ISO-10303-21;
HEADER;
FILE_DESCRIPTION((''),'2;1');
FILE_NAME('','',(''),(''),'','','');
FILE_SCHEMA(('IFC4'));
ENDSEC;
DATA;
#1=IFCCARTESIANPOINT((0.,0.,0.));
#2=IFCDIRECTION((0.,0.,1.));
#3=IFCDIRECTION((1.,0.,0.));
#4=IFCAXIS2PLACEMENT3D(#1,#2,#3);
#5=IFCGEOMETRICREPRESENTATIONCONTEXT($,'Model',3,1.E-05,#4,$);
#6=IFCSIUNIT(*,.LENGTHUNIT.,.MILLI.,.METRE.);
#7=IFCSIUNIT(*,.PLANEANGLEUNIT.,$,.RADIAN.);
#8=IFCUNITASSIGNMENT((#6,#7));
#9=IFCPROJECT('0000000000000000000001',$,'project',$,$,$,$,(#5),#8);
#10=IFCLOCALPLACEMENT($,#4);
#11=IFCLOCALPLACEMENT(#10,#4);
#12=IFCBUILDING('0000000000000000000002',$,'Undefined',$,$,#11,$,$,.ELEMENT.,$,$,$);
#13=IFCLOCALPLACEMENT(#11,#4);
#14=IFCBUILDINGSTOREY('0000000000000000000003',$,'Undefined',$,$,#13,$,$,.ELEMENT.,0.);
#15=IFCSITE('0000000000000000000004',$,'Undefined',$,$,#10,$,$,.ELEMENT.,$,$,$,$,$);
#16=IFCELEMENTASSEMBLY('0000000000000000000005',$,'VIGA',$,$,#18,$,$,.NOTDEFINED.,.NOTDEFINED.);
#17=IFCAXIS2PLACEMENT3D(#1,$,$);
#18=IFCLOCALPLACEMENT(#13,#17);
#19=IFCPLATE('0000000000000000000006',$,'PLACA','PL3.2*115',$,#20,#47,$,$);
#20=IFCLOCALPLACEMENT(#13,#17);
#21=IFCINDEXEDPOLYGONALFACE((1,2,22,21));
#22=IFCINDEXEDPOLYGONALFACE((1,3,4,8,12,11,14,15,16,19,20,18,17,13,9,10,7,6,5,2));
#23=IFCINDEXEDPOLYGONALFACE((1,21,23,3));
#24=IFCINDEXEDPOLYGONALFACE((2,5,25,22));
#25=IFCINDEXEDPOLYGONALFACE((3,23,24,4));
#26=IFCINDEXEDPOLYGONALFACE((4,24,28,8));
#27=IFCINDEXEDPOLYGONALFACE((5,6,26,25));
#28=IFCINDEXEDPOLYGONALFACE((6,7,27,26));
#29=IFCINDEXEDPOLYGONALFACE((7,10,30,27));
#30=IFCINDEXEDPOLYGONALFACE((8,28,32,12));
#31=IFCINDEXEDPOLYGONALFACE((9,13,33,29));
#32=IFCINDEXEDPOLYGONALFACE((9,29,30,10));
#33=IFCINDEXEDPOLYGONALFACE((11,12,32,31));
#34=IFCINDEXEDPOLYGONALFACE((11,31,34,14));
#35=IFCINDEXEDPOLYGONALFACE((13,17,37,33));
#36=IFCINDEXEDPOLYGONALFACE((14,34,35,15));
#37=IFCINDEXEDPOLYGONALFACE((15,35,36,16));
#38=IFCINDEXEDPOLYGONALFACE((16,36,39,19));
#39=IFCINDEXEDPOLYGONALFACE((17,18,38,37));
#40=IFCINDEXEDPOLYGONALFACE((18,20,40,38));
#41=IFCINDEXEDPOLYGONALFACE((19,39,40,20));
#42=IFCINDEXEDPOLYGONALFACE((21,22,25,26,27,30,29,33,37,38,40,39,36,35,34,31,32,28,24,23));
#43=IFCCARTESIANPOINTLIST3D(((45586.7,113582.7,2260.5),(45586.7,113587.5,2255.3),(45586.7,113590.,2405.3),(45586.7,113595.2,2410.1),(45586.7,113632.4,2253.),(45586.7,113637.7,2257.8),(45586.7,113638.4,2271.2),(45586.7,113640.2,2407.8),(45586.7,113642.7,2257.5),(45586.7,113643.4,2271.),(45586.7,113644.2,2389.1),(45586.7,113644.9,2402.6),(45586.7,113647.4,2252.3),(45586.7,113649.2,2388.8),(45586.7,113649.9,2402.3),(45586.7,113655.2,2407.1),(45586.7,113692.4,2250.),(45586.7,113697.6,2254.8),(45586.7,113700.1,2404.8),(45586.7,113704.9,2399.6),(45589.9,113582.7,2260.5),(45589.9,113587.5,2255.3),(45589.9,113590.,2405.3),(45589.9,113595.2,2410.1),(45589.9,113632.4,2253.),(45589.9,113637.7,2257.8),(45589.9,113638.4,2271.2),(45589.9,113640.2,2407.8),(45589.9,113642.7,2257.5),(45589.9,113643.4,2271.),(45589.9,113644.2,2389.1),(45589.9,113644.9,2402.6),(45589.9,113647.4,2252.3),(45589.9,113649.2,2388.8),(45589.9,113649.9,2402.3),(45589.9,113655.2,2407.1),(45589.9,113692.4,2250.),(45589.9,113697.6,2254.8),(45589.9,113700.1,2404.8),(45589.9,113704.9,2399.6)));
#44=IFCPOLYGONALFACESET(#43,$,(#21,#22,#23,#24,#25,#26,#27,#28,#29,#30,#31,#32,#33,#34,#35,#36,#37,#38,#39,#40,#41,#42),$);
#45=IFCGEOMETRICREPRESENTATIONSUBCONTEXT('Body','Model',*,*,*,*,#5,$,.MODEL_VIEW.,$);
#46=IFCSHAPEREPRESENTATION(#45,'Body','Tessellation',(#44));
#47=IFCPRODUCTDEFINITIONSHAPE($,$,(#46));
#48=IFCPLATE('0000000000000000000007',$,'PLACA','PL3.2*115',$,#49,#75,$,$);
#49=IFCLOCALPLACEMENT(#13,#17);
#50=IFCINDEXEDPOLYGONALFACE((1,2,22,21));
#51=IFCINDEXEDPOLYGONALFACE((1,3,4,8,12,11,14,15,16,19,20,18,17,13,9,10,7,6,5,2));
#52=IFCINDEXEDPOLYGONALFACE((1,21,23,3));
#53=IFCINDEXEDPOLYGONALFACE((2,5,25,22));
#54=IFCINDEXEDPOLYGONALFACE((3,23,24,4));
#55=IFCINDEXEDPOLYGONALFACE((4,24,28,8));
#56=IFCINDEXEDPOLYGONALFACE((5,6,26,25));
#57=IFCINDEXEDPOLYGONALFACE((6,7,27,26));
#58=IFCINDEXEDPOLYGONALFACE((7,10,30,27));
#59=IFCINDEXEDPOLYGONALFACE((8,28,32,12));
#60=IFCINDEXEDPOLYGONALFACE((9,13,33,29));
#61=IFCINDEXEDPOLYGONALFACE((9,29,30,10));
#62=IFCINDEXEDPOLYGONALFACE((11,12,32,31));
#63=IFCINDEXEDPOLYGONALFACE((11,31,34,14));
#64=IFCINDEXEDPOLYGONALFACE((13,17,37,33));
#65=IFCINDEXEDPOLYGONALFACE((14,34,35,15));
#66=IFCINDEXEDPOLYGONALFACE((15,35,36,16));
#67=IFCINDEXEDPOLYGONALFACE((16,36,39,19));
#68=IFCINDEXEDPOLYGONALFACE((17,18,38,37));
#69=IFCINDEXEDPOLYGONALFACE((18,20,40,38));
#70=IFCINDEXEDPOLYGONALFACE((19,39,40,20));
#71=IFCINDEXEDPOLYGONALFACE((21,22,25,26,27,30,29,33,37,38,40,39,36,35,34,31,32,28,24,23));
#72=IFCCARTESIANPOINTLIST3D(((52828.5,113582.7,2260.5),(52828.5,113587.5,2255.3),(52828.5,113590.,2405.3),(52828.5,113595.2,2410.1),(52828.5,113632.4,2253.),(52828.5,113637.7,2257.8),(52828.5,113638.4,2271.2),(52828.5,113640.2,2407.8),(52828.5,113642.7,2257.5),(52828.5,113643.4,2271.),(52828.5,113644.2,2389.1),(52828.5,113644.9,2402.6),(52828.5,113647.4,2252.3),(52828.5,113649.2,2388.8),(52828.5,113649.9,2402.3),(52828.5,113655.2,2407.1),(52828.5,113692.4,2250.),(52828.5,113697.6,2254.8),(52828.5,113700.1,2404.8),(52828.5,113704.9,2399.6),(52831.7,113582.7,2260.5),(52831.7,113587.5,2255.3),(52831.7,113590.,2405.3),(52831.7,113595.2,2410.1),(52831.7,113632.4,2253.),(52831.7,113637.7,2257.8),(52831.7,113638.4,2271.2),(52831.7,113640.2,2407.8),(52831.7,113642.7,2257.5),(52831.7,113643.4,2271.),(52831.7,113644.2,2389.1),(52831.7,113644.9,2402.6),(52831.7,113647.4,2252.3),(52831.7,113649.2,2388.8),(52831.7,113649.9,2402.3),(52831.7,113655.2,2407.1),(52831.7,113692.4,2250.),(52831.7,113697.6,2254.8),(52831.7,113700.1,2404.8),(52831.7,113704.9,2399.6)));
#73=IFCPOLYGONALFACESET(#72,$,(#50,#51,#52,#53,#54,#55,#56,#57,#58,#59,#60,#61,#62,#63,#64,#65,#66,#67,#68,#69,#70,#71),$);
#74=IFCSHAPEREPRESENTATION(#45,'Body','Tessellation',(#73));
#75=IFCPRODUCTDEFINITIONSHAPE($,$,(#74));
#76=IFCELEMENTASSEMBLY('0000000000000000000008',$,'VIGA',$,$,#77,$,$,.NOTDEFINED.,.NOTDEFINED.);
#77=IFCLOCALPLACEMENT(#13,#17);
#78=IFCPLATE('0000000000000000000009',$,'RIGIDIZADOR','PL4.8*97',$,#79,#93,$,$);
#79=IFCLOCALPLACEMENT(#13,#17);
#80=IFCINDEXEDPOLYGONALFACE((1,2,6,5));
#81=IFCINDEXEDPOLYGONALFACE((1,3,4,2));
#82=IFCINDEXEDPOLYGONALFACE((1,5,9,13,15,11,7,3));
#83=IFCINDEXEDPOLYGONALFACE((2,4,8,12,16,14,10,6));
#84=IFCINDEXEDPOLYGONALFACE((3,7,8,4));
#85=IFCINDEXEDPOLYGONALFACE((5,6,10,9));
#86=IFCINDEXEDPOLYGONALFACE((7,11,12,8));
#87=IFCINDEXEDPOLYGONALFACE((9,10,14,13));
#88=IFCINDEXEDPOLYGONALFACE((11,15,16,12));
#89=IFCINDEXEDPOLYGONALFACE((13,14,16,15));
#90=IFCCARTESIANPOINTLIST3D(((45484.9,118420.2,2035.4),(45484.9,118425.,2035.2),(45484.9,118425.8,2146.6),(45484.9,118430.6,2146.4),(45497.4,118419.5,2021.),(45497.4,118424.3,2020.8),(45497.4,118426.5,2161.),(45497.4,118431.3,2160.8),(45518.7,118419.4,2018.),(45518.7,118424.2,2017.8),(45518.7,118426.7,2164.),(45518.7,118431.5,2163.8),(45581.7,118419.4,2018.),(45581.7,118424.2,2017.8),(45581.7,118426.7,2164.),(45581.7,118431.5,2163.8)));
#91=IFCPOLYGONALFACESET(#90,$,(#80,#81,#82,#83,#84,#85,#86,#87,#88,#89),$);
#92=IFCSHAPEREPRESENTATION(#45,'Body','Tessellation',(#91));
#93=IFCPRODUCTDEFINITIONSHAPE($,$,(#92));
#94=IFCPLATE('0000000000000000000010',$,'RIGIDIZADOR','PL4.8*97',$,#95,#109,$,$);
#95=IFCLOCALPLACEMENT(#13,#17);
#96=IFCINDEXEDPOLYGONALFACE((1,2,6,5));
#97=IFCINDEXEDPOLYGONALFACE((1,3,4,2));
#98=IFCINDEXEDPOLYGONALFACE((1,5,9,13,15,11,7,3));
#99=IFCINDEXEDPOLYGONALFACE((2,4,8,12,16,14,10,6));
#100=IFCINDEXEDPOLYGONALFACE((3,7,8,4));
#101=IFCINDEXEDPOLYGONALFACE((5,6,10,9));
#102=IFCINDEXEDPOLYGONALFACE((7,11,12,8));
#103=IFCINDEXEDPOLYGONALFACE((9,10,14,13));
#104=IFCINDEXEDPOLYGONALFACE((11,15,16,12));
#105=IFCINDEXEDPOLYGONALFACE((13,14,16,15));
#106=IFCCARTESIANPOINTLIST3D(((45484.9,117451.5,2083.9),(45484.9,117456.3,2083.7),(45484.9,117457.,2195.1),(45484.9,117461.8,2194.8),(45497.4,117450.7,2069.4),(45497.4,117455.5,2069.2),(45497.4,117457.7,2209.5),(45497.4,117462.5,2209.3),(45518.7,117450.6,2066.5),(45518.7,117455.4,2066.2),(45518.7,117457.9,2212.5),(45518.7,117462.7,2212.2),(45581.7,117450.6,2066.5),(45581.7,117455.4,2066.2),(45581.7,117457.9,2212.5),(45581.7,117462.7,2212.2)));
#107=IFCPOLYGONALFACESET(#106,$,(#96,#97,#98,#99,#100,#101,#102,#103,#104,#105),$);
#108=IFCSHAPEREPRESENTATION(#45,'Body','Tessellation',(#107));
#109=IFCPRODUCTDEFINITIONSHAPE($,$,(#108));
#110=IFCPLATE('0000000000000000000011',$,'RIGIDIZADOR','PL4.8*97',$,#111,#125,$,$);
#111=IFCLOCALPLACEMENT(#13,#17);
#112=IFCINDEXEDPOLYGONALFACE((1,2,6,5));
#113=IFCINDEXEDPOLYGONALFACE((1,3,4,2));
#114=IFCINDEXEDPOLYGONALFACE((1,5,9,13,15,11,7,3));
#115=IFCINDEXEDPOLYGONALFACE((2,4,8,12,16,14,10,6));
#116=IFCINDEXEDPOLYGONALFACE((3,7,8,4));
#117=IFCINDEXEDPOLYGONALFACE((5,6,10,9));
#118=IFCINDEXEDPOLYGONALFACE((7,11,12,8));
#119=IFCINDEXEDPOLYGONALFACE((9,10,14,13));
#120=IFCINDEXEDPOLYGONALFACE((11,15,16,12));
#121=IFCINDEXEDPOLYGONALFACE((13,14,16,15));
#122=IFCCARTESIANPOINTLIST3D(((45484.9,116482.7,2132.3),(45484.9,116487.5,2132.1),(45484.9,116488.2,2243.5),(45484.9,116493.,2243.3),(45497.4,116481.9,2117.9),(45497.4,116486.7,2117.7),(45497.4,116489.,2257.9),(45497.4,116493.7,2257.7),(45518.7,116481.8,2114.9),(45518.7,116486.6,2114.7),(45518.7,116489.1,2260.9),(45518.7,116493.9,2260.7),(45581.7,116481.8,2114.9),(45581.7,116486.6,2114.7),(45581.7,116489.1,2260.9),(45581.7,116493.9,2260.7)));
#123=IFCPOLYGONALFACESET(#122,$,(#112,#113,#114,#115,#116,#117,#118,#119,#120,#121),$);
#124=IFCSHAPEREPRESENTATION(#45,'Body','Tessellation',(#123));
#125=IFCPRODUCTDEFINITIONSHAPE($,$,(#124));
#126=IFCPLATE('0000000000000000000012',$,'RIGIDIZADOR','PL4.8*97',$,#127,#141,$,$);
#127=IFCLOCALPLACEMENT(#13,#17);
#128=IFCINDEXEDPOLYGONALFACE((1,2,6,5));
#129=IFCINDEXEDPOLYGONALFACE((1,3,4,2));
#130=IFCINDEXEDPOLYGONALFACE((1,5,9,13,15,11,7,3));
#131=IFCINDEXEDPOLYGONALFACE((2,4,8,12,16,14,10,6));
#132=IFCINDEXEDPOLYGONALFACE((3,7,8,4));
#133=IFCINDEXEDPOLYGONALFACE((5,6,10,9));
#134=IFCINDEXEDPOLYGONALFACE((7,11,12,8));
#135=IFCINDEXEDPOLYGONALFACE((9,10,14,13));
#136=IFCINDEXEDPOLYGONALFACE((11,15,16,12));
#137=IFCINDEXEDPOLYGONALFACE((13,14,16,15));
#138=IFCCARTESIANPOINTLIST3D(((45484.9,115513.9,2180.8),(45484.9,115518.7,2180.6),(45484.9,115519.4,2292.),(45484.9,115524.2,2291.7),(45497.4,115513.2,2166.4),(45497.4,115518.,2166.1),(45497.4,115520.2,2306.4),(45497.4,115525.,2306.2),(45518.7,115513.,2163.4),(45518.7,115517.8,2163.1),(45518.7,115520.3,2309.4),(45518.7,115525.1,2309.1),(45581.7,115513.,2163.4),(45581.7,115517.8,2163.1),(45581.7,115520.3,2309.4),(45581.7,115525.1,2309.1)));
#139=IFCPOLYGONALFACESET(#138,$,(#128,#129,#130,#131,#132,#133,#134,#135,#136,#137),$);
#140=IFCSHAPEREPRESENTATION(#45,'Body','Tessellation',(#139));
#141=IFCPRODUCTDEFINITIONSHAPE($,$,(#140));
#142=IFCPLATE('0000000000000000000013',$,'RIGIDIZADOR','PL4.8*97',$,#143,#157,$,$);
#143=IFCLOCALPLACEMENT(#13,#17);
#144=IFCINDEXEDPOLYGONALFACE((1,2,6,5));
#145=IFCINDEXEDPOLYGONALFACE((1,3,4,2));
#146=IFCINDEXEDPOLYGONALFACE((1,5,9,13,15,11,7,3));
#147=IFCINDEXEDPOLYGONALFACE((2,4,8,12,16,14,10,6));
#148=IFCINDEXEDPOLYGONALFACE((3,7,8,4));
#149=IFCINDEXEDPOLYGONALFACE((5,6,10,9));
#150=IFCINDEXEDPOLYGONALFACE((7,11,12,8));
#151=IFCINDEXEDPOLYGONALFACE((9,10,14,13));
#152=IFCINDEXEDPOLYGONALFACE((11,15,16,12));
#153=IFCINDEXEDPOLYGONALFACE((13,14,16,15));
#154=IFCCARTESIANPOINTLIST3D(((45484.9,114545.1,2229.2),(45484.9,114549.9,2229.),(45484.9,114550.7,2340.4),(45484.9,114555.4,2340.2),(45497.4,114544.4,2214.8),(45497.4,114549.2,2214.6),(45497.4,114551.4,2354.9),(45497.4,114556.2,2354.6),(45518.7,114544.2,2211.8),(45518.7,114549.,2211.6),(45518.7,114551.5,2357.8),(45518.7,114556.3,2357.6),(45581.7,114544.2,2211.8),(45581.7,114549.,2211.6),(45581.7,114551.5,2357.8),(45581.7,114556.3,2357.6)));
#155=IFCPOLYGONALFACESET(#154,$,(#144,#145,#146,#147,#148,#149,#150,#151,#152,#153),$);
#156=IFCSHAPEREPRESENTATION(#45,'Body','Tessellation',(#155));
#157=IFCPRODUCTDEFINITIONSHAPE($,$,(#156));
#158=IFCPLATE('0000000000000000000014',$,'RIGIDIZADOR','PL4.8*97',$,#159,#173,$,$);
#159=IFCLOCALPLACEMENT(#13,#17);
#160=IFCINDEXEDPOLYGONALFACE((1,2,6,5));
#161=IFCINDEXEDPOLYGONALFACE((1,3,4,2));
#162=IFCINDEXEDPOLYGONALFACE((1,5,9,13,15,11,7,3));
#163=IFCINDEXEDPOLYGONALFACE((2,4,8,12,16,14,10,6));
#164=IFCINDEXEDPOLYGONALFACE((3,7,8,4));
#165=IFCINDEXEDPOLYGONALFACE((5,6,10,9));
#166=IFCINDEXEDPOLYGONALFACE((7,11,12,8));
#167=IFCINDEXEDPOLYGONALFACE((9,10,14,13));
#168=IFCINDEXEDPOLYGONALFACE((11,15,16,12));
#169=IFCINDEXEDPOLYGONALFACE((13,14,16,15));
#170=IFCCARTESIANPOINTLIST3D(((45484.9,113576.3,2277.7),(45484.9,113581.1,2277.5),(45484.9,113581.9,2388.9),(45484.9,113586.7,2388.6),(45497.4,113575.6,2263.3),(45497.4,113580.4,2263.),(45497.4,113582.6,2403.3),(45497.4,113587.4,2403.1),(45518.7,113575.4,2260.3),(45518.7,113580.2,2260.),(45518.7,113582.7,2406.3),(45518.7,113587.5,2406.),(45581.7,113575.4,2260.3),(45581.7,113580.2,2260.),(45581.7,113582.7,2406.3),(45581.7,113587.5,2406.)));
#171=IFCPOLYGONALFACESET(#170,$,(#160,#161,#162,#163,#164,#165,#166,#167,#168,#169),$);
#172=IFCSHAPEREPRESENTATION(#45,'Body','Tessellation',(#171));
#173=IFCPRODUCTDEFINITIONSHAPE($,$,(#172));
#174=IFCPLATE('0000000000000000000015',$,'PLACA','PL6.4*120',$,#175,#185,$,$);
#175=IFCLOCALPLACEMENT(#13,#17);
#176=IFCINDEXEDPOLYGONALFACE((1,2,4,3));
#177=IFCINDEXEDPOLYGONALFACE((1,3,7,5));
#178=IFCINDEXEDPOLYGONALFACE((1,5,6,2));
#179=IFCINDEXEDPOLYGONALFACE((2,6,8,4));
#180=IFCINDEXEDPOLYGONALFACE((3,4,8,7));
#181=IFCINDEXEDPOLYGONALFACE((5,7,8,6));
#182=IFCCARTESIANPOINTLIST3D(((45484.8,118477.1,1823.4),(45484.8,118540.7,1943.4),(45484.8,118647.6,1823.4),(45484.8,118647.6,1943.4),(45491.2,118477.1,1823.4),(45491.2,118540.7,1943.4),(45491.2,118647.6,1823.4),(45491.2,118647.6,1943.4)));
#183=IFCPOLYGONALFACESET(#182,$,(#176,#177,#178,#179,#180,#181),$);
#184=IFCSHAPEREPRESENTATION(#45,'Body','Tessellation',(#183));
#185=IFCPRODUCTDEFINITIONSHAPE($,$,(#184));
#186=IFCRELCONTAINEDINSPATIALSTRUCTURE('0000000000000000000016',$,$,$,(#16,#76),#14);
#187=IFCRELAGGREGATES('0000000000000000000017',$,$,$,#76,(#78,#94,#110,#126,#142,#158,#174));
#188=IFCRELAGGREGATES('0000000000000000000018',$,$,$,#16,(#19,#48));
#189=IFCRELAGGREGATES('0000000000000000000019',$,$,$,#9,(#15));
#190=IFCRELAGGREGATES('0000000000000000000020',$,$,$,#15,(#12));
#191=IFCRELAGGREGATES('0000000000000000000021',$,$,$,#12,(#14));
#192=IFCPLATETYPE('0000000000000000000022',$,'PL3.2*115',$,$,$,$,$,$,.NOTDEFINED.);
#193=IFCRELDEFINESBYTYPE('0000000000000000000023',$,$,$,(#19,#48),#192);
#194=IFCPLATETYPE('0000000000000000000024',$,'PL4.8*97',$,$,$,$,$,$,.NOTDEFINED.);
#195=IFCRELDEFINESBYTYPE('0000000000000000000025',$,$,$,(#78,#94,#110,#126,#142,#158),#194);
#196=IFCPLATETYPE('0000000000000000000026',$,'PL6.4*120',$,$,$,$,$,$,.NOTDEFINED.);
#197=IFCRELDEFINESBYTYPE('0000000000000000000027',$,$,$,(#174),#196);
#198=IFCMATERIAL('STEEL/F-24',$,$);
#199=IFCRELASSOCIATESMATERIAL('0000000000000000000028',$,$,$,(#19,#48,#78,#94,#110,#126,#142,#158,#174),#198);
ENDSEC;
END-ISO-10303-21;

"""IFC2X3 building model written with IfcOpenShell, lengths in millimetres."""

from ifc_helpers import new_model, si_unit, frame, origin_with_axes, place, context, subcontext, project, spatial, polyline, outline, extrude, material, type_object, element, aggregate, save


model = new_model("IFC2X3")

# Units and contexts
model_context = context("Model", 3, precision=1e-05, world=origin_with_axes())
body_context = subcontext(model_context, "Body", "Model", "MODEL_VIEW")
ifc_project = project(units=[si_unit("LENGTHUNIT", "METRE", prefix="MILLI"), si_unit("PLANEANGLEUNIT", "RADIAN")], contexts=[model_context])

# Site, building, storey
site_placement = place(None, origin_with_axes())
site = spatial("IfcSite", under=ifc_project, at=site_placement, Name="Undefined", CompositionType="ELEMENT")
building_placement = place(site_placement, origin_with_axes())
building = spatial("IfcBuilding", under=site, at=building_placement, Name="Undefined", CompositionType="ELEMENT")
storey_placement = place(building_placement, origin_with_axes())
storey = spatial("IfcBuildingStorey", under=building, at=storey_placement, Name="Undefined", CompositionType="ELEMENT", Elevation=0.0)

# Element assemblies, plates
ifc_material_1 = material(Name="STEEL/F-24")
plate_type_1 = type_object("IfcPlateType", Name="PL3.2*115", PredefinedType="NOTDEFINED")
assembly_1_placement = place(storey_placement, origin_with_axes())
assembly_1 = element("IfcElementAssembly", 1, at=assembly_1_placement, inside=storey, Name="VIGA", AssemblyPlace="NOTDEFINED", PredefinedType="NOTDEFINED")
plate_1_placement = place(assembly_1_placement, frame((45588.3, 113705.1, 2404.6), z_axis=(1.0, 0.0, 0.0), x_axis=(0.0, -0.998752, 0.04995)))
plate_1 = element("IfcPlate", 2, at=plate_1_placement, type_object=plate_type_1, material=ifc_material_1, Name="PLACA", Description="PL3.2*115", context=body_context, shape_type="SweptSolid", body=[
    extrude(outline(polyline([(0.0, 5.0), (5.0, 0.0), (50.0, 0.0), (55.0, 5.0), (55.0, 18.5), (60.0, 18.5), (60.0, 5.0), (65.0, 0.0), (110.0, 0.0), (115.0, 5.0), (115.0, 150.0), (110.0, 155.0), (65.0, 155.0), (60.0, 150.0), (60.0, 136.5), (55.0, 136.5), (55.0, 150.0), (50.0, 155.0), (5.0, 155.0), (0.0, 150.0), (0.0, 5.0)])), frame((0.0, 0.0, -1.6), z_axis=(0.0, 0.0, 1.0), x_axis=(1.0, 0.0, 0.0)), (0.0, 0.0, 1.0), 3.2),
])
plate_2_placement = place(assembly_1_placement, frame((52830.1, 113705.1, 2404.6), z_axis=(1.0, 0.0, 0.0), x_axis=(0.0, -0.998752, 0.04995)))
plate_2 = element("IfcPlate", 3, at=plate_2_placement, type_object=plate_type_1, material=ifc_material_1, Name="PLACA", Description="PL3.2*115", context=body_context, shape_type="SweptSolid", body=[
    extrude(outline(polyline([(0.0, 5.0), (5.0, 0.0), (50.0, 0.0), (55.0, 5.0), (55.0, 18.5), (60.0, 18.5), (60.0, 5.0), (65.0, 0.0), (110.0, 0.0), (115.0, 5.0), (115.0, 150.0), (110.0, 155.0), (65.0, 155.0), (60.0, 150.0), (60.0, 136.5), (55.0, 136.5), (55.0, 150.0), (50.0, 155.0), (5.0, 155.0), (0.0, 150.0), (0.0, 5.0)])), frame((0.0, 0.0, -1.6), z_axis=(0.0, 0.0, 1.0), x_axis=(1.0, 0.0, 0.0)), (0.0, 0.0, 1.0), 3.2),
])
assembly_2_placement = place(storey_placement, origin_with_axes())
assembly_2 = element("IfcElementAssembly", 4, at=assembly_2_placement, inside=storey, Name="VIGA", AssemblyPlace="NOTDEFINED", PredefinedType="NOTDEFINED")
plate_type_2 = type_object("IfcPlateType", Name="PL4.8*97", PredefinedType="NOTDEFINED")
plate_3_placement = place(assembly_2_placement, frame((45581.7, 118429.1, 2163.9), z_axis=(0.0, -0.998752, 0.04995), x_axis=(-1.0, 0.0, 0.0)))
plate_3 = element("IfcPlate", 5, at=plate_3_placement, type_object=plate_type_2, material=ifc_material_1, Name="RIGIDIZADOR", Description="PL4.8*97", context=body_context, shape_type="SweptSolid", body=[
    extrude(outline(polyline([(0.0, 0.0), (63.0, 0.0), (84.3, 3.0), (96.8, 17.4), (96.8, 128.7), (84.3, 143.2), (63.0, 146.2), (0.0, 146.2), (0.0, 0.0)])), frame((0.0, 0.0, -2.4), z_axis=(0.0, 0.0, 1.0), x_axis=(1.0, 0.0, 0.0)), (0.0, 0.0, 1.0), 4.8),
])
plate_4_placement = place(assembly_2_placement, frame((45581.7, 117460.3, 2212.4), z_axis=(0.0, -0.998752, 0.04995), x_axis=(-1.0, 0.0, 0.0)))
plate_4 = element("IfcPlate", 6, at=plate_4_placement, type_object=plate_type_2, material=ifc_material_1, Name="RIGIDIZADOR", Description="PL4.8*97", context=body_context, shape_type="SweptSolid", body=[
    extrude(outline(polyline([(0.0, 0.0), (63.0, 0.0), (84.3, 3.0), (96.8, 17.4), (96.8, 128.7), (84.3, 143.2), (63.0, 146.2), (0.0, 146.2), (0.0, 0.0)])), frame((0.0, 0.0, -2.4), z_axis=(0.0, 0.0, 1.0), x_axis=(1.0, 0.0, 0.0)), (0.0, 0.0, 1.0), 4.8),
])
plate_5_placement = place(assembly_2_placement, frame((45581.7, 116491.5, 2260.8), z_axis=(0.0, -0.998752, 0.04995), x_axis=(-1.0, 0.0, 0.0)))
plate_5 = element("IfcPlate", 7, at=plate_5_placement, type_object=plate_type_2, material=ifc_material_1, Name="RIGIDIZADOR", Description="PL4.8*97", context=body_context, shape_type="SweptSolid", body=[
    extrude(outline(polyline([(0.0, 0.0), (63.0, 0.0), (84.3, 3.0), (96.8, 17.4), (96.8, 128.7), (84.3, 143.2), (63.0, 146.2), (0.0, 146.2), (0.0, 0.0)])), frame((0.0, 0.0, -2.4), z_axis=(0.0, 0.0, 1.0), x_axis=(1.0, 0.0, 0.0)), (0.0, 0.0, 1.0), 4.8),
])
plate_6_placement = place(assembly_2_placement, frame((45581.7, 115522.7, 2309.3), z_axis=(0.0, -0.998752, 0.04995), x_axis=(-1.0, 0.0, 0.0)))
plate_6 = element("IfcPlate", 8, at=plate_6_placement, type_object=plate_type_2, material=ifc_material_1, Name="RIGIDIZADOR", Description="PL4.8*97", context=body_context, shape_type="SweptSolid", body=[
    extrude(outline(polyline([(0.0, 0.0), (63.0, 0.0), (84.3, 3.0), (96.8, 17.4), (96.8, 128.7), (84.3, 143.2), (63.0, 146.2), (0.0, 146.2), (0.0, 0.0)])), frame((0.0, 0.0, -2.4), z_axis=(0.0, 0.0, 1.0), x_axis=(1.0, 0.0, 0.0)), (0.0, 0.0, 1.0), 4.8),
])
plate_7_placement = place(assembly_2_placement, frame((45581.7, 114553.9, 2357.7), z_axis=(0.0, -0.998752, 0.04995), x_axis=(-1.0, 0.0, 0.0)))
plate_7 = element("IfcPlate", 9, at=plate_7_placement, type_object=plate_type_2, material=ifc_material_1, Name="RIGIDIZADOR", Description="PL4.8*97", context=body_context, shape_type="SweptSolid", body=[
    extrude(outline(polyline([(0.0, 0.0), (63.0, 0.0), (84.3, 3.0), (96.8, 17.4), (96.8, 128.7), (84.3, 143.2), (63.0, 146.2), (0.0, 146.2), (0.0, 0.0)])), frame((0.0, 0.0, -2.4), z_axis=(0.0, 0.0, 1.0), x_axis=(1.0, 0.0, 0.0)), (0.0, 0.0, 1.0), 4.8),
])
plate_8_placement = place(assembly_2_placement, frame((45581.7, 113585.1, 2406.2), z_axis=(0.0, -0.998752, 0.04995), x_axis=(-1.0, 0.0, 0.0)))
plate_8 = element("IfcPlate", 10, at=plate_8_placement, type_object=plate_type_2, material=ifc_material_1, Name="RIGIDIZADOR", Description="PL4.8*97", context=body_context, shape_type="SweptSolid", body=[
    extrude(outline(polyline([(0.0, 0.0), (63.0, 0.0), (84.3, 3.0), (96.8, 17.4), (96.8, 128.7), (84.3, 143.2), (63.0, 146.2), (0.0, 146.2), (0.0, 0.0)])), frame((0.0, 0.0, -2.4), z_axis=(0.0, 0.0, 1.0), x_axis=(1.0, 0.0, 0.0)), (0.0, 0.0, 1.0), 4.8),
])
plate_type_3 = type_object("IfcPlateType", Name="PL6.4*120", PredefinedType="NOTDEFINED")
plate_9_placement = place(assembly_2_placement, frame((45488.0, 118540.7, 1943.4), z_axis=(-1.0, 0.0, 0.0), x_axis=(0.0, 1.0, 0.0)))
plate_9 = element("IfcPlate", 11, at=plate_9_placement, type_object=plate_type_3, material=ifc_material_1, Name="PLACA", Description="PL6.4*120", context=body_context, shape_type="SweptSolid", body=[
    extrude(outline(polyline([(0.0, 0.0), (106.8, 0.0), (106.8, 120.0), (-63.7, 120.0), (0.0, 0.0)])), frame((0.0, 0.0, -3.2), z_axis=(0.0, 0.0, 1.0), x_axis=(1.0, 0.0, 0.0)), (0.0, 0.0, 1.0), 6.4),
])
aggregate(assembly_2, [plate_3, plate_4, plate_5, plate_6, plate_7, plate_8, plate_9])

aggregate(assembly_1, [plate_1, plate_2])

save(model, "model.ifc")
